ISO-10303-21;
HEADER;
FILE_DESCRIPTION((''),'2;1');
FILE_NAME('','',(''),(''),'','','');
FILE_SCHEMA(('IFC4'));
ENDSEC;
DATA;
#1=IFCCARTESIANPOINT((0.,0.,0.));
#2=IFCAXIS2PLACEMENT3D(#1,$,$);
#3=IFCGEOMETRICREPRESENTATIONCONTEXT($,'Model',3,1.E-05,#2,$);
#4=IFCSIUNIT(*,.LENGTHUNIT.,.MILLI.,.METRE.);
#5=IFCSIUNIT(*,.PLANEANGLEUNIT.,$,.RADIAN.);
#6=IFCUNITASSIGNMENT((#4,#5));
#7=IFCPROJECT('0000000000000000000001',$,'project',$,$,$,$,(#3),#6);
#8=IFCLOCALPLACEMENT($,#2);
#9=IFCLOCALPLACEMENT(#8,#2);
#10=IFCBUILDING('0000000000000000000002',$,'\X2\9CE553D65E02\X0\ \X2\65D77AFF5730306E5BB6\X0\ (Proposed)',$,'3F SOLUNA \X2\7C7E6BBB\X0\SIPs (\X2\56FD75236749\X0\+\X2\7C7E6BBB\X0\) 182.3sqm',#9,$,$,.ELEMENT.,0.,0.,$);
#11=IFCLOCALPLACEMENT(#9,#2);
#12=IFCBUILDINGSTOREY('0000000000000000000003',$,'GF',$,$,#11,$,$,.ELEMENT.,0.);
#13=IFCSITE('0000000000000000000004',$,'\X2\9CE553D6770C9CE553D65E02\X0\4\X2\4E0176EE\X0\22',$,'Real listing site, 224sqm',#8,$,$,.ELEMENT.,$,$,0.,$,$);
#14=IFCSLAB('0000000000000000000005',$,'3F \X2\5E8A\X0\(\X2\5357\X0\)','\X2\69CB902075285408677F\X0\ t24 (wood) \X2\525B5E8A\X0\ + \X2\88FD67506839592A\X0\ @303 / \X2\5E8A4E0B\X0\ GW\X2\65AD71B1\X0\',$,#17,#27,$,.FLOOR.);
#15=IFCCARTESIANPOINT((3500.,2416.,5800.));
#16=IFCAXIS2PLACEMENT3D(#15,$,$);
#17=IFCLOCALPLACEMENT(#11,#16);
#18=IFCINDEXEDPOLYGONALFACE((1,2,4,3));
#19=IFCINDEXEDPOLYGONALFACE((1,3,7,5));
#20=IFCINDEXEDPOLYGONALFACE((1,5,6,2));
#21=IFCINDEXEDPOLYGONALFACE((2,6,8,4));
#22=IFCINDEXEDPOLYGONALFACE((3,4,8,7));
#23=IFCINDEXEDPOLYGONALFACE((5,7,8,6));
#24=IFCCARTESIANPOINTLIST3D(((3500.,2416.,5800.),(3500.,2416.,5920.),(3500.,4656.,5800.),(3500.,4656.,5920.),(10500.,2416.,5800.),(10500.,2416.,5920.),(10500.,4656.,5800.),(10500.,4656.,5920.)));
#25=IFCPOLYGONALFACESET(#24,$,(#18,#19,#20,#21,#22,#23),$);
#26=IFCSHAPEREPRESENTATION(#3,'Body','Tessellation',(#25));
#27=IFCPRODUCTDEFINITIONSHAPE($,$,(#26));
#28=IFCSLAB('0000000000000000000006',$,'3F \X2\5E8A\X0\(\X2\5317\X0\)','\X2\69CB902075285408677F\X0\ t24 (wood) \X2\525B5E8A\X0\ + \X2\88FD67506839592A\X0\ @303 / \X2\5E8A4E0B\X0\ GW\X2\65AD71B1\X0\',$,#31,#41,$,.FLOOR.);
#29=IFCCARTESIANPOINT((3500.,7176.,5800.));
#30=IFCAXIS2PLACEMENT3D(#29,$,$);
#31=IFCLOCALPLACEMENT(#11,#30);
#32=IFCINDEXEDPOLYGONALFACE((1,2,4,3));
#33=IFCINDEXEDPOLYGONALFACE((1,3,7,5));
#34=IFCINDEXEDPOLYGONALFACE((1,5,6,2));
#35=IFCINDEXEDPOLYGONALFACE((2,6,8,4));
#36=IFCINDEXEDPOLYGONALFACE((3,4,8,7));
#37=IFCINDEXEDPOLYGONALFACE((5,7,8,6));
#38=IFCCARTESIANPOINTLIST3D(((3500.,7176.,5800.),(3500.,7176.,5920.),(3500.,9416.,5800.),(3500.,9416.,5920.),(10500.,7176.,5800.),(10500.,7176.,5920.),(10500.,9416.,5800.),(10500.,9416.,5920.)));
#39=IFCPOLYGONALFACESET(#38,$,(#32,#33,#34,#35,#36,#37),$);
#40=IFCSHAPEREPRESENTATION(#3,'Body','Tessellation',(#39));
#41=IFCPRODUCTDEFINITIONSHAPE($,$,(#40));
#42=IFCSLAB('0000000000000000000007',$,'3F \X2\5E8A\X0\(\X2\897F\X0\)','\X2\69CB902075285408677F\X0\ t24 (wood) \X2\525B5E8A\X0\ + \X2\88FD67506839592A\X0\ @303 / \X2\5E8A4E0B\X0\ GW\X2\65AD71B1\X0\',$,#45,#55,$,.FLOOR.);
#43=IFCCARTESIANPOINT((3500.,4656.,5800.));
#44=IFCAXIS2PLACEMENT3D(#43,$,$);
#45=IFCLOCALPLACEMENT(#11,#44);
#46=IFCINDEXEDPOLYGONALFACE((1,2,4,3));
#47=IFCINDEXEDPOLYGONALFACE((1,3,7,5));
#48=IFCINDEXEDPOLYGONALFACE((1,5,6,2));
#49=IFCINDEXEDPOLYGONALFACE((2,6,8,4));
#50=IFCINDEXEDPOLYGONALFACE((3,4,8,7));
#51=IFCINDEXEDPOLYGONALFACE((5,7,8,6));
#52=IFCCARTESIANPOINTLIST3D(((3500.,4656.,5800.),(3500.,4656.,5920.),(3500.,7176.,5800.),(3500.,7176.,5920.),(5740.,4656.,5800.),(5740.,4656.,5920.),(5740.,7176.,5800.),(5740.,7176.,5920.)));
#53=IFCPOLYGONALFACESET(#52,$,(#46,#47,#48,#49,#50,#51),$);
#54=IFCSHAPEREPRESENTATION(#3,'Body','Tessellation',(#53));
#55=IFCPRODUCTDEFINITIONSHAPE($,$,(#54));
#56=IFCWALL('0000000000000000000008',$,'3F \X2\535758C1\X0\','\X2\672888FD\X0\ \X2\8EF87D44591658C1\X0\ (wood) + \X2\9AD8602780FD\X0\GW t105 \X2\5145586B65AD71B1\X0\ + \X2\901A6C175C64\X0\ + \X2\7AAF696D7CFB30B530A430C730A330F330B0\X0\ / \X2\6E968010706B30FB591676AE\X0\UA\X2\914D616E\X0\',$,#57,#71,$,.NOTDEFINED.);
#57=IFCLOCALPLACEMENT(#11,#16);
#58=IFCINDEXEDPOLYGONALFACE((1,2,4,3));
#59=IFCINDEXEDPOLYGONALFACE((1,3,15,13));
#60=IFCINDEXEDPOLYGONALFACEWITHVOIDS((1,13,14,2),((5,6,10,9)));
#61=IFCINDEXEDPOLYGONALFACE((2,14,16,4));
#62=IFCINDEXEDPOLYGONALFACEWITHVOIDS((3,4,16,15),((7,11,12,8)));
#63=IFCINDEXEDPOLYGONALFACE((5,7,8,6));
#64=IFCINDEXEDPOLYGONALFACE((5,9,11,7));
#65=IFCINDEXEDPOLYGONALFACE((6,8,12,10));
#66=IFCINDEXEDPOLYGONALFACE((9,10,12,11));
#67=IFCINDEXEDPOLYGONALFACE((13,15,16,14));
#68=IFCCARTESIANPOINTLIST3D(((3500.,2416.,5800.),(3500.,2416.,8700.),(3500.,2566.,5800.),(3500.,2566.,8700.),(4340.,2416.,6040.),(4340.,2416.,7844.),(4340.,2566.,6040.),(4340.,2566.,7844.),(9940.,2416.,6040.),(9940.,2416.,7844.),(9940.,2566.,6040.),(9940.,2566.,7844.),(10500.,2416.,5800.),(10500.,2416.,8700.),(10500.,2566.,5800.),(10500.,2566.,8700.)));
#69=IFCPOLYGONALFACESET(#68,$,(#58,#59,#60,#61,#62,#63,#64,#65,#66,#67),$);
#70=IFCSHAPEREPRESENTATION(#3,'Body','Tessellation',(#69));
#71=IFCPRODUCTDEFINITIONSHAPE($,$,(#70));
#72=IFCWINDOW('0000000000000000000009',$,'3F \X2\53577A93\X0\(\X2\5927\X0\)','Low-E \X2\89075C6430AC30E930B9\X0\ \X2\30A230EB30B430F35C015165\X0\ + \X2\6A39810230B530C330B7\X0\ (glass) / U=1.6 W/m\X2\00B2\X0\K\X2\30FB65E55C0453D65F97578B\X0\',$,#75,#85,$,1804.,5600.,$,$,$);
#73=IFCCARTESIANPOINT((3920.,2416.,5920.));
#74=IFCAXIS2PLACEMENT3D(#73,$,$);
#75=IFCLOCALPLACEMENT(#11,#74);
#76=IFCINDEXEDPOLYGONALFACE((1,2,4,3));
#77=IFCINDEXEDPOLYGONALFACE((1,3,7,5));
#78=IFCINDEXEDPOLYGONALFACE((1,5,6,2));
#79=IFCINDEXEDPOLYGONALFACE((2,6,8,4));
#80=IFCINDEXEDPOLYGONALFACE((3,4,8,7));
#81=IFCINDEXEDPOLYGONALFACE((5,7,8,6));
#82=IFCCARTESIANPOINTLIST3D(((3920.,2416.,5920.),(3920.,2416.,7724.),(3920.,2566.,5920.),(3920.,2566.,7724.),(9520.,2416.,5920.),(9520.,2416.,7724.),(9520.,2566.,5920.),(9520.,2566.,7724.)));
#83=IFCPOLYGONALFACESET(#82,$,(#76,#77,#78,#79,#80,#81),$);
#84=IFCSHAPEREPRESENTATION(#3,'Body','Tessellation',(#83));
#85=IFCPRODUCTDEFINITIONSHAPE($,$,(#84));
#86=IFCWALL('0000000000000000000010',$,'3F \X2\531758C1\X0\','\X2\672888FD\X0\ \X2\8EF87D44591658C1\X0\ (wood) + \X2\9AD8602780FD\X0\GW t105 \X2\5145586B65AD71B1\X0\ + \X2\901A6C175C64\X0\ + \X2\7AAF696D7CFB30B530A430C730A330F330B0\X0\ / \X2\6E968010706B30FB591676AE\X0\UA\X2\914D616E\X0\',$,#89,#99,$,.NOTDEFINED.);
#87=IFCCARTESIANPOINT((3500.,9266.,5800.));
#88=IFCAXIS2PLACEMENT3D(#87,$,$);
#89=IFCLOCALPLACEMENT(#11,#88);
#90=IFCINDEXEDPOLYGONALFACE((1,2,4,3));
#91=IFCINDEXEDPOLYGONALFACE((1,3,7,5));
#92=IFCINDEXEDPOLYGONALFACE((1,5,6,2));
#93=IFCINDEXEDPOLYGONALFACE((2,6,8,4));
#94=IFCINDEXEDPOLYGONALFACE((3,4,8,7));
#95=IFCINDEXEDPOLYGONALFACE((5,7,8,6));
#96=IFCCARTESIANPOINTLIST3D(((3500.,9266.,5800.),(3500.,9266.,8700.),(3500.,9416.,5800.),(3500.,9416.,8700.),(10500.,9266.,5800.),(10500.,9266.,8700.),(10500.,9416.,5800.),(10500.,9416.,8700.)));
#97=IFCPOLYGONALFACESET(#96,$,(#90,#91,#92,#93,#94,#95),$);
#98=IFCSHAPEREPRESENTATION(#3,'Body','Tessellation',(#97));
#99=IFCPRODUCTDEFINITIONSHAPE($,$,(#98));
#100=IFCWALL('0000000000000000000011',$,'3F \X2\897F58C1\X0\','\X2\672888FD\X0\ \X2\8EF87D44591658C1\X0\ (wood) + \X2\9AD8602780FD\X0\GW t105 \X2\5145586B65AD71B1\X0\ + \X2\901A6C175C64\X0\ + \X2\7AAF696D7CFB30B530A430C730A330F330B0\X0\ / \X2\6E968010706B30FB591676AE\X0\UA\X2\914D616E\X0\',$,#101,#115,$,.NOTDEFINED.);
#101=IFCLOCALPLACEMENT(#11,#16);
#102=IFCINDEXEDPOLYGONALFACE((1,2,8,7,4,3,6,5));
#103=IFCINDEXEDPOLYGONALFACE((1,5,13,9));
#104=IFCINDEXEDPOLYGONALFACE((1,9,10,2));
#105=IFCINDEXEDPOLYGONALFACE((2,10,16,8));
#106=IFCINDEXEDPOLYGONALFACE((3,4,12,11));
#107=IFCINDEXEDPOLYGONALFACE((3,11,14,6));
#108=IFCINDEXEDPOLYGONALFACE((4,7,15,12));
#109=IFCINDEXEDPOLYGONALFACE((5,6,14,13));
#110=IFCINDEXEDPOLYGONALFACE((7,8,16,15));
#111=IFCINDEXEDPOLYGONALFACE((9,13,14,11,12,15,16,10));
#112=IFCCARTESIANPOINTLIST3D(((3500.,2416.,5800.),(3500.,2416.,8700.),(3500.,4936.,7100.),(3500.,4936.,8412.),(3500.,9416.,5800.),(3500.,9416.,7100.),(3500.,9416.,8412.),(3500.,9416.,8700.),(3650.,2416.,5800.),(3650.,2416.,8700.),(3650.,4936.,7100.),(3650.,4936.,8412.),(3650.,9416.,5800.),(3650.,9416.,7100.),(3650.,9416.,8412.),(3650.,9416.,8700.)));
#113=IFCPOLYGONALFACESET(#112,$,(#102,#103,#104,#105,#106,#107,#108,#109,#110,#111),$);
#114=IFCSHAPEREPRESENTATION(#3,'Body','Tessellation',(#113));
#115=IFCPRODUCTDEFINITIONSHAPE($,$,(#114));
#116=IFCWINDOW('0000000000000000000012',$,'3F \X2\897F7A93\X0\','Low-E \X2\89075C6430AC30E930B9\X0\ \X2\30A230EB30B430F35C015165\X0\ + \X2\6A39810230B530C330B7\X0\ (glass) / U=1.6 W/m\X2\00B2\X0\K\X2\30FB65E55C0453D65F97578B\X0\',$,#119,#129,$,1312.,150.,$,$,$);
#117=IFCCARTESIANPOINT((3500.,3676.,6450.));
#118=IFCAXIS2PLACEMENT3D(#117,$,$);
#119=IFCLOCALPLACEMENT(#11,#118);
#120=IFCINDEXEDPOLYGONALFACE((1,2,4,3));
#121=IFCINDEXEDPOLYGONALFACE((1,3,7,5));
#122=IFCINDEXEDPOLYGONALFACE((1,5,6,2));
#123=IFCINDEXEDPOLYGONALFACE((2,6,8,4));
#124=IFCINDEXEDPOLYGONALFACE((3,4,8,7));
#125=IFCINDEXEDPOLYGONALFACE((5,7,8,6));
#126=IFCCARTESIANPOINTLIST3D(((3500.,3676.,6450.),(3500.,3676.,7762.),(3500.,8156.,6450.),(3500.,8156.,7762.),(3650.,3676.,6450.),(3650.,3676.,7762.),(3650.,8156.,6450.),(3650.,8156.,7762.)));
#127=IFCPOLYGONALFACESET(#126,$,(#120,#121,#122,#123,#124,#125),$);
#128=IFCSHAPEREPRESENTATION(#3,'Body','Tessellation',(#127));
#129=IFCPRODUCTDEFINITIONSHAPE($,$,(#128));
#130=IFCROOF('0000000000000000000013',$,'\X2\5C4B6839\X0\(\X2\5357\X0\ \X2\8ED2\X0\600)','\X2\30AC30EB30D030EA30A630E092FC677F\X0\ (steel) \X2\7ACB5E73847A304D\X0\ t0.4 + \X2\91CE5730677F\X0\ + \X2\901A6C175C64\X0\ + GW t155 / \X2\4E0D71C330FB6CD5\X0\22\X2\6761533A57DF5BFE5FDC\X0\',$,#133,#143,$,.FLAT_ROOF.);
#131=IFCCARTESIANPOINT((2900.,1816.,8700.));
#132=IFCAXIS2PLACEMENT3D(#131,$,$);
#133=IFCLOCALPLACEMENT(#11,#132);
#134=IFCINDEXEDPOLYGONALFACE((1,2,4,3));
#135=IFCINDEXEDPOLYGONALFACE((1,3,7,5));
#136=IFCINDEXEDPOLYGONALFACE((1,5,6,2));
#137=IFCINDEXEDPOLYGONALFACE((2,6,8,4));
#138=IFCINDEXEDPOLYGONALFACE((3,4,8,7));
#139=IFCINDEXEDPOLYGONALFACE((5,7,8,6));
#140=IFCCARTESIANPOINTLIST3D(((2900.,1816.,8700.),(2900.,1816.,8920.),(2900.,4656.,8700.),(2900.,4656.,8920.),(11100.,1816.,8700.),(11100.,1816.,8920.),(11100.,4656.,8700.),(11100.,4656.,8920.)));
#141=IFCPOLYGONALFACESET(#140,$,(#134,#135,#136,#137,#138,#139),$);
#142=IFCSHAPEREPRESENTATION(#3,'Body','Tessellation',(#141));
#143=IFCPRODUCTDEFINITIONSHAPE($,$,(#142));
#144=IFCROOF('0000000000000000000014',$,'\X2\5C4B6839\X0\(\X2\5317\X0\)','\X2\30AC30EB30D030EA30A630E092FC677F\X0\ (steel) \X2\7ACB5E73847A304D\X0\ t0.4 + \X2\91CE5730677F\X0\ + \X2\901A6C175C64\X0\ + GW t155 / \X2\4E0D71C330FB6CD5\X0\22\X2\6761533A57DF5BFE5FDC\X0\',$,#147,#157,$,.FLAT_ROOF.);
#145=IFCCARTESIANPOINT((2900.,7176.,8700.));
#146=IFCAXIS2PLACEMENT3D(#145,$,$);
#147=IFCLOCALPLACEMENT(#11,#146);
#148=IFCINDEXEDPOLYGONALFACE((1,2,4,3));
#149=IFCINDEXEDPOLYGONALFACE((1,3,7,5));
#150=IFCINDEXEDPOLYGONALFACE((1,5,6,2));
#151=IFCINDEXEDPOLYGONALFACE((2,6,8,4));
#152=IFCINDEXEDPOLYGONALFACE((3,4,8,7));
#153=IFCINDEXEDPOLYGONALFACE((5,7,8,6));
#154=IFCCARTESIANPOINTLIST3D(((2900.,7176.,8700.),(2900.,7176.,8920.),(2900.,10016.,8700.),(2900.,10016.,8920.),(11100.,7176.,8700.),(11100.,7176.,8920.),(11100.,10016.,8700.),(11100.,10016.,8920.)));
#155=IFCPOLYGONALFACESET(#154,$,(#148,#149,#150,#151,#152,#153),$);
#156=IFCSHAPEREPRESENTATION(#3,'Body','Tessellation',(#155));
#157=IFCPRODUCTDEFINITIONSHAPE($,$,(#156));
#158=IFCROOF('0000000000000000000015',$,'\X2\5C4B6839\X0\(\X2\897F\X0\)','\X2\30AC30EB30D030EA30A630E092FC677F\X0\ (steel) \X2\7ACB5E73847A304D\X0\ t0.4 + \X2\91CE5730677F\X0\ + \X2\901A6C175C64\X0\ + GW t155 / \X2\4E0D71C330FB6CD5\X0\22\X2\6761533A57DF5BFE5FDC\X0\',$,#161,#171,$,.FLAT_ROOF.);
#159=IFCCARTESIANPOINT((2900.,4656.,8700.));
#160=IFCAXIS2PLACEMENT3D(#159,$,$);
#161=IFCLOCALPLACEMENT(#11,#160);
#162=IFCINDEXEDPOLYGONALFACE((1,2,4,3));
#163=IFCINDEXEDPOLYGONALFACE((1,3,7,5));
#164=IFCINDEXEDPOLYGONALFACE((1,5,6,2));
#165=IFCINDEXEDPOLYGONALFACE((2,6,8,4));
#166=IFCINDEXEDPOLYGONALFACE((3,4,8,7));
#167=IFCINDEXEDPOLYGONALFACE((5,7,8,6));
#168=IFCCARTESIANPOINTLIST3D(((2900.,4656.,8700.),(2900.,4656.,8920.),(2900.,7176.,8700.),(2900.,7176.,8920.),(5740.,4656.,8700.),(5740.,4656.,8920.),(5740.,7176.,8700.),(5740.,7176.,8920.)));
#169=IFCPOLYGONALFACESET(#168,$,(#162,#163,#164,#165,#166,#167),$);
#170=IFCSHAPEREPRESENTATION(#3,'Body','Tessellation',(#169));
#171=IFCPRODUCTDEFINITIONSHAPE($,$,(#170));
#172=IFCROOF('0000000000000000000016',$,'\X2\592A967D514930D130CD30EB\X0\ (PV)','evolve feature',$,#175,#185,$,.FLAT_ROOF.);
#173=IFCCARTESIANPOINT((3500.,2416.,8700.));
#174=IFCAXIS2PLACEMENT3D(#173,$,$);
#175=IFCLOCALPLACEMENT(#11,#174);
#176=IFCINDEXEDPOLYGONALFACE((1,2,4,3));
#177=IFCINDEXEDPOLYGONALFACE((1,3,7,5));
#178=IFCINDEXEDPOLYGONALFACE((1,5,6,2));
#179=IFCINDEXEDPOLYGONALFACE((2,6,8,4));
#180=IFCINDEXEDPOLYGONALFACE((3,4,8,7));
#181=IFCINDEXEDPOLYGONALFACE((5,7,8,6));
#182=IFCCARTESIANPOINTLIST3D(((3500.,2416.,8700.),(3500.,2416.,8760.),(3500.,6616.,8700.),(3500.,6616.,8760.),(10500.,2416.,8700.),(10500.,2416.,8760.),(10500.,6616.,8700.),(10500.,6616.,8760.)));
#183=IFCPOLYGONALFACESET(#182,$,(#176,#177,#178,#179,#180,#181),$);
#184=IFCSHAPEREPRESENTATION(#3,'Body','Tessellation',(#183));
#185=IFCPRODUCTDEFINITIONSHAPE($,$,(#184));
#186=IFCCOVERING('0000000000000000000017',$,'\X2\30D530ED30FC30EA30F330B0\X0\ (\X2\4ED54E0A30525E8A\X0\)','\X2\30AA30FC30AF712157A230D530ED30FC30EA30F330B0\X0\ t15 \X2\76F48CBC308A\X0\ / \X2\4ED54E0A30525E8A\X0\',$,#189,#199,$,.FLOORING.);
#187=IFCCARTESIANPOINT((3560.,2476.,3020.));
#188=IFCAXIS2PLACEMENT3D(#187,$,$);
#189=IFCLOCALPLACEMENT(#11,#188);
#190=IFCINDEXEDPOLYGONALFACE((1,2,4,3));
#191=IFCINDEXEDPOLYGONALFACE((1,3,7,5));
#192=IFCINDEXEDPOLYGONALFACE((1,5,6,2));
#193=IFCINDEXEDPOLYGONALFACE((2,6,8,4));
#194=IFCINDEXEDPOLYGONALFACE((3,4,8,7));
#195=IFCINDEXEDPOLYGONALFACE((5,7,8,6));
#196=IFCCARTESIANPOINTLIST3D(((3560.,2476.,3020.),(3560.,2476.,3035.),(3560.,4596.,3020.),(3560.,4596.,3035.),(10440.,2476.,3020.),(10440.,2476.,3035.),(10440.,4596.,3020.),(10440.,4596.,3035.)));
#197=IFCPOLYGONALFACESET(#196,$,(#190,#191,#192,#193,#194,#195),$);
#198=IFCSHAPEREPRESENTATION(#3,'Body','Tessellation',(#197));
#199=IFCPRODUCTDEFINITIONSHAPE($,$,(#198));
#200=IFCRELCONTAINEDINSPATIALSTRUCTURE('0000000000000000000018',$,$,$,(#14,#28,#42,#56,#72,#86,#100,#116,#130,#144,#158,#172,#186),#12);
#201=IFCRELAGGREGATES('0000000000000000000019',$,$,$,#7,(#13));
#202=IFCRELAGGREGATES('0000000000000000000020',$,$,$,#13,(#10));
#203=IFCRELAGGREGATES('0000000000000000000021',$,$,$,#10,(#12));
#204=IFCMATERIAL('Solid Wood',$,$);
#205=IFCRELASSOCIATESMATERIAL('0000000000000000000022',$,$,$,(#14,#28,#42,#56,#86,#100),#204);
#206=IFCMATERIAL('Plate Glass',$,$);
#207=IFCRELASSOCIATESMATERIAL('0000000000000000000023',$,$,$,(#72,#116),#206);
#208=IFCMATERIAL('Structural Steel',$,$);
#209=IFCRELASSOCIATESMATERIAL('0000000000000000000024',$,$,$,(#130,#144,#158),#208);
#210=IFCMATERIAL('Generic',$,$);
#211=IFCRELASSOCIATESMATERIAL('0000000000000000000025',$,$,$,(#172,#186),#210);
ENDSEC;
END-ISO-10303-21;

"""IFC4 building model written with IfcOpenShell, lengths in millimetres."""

from ifc_helpers import new_model, si_unit, frame, frame_2d, origin, place, context, project, spatial, rectangle, extrude, material, element, fill, save


model = new_model("IFC4")

# Units and contexts
model_context = context("Model", 3, precision=1e-05, world=origin())
ifc_project = project(units=[si_unit("LENGTHUNIT", "METRE", prefix="MILLI"), si_unit("PLANEANGLEUNIT", "RADIAN")], contexts=[model_context])

# Site, building, storey
site_placement = place(None, origin())
site = spatial("IfcSite", under=ifc_project, at=site_placement, Name="鳥取県鳥取市4丁目22", ObjectType="Real listing site, 224sqm", CompositionType="ELEMENT", RefElevation=0.0)
building_placement = place(site_placement, origin())
building = spatial("IfcBuilding", under=site, at=building_placement, Name="鳥取市 旗竿地の家 (Proposed)", ObjectType="3F SOLUNA 籾殻SIPs (国産杉+籾殻) 182.3sqm", CompositionType="ELEMENT", ElevationOfRefHeight=0.0, ElevationOfTerrain=0.0)
storey_placement = place(building_placement, origin())
storey = spatial("IfcBuildingStorey", under=building, at=storey_placement, Name="GF", CompositionType="ELEMENT", Elevation=0.0)

# Slabs
ifc_material_1 = material(Name="Solid Wood")
slab_1_placement = place(storey_placement, frame((3500.0, 2416.0, 5800.0)))
element("IfcSlab", 1, at=slab_1_placement, inside=storey, material=ifc_material_1, Name="3F 床(南)", Description="構造用合板 t24 (wood) 剛床 + 製材根太 @303 / 床下 GW断熱", PredefinedType="FLOOR", context=model_context, shape_type="SweptSolid", body=[
    extrude(rectangle(XDim=7000.0, YDim=2240.0, at=frame_2d((3500.0, 1120.0))), frame((3500.0, 2416.0, 5800.0)), (0.0, 0.0, 1.0), 120.0),
])
slab_2_placement = place(storey_placement, frame((3500.0, 7176.0, 5800.0)))
element("IfcSlab", 2, at=slab_2_placement, inside=storey, material=ifc_material_1, Name="3F 床(北)", Description="構造用合板 t24 (wood) 剛床 + 製材根太 @303 / 床下 GW断熱", PredefinedType="FLOOR", context=model_context, shape_type="SweptSolid", body=[
    extrude(rectangle(XDim=7000.0, YDim=2240.0, at=frame_2d((3500.0, 1120.0))), frame((3500.0, 7176.0, 5800.0)), (0.0, 0.0, 1.0), 120.0),
])
slab_3_placement = place(storey_placement, frame((3500.0, 4656.0, 5800.0)))
element("IfcSlab", 3, at=slab_3_placement, inside=storey, material=ifc_material_1, Name="3F 床(西)", Description="構造用合板 t24 (wood) 剛床 + 製材根太 @303 / 床下 GW断熱", PredefinedType="FLOOR", context=model_context, shape_type="SweptSolid", body=[
    extrude(rectangle(XDim=2240.0, YDim=2520.0, at=frame_2d((1120.0, 1260.0))), frame((3500.0, 4656.0, 5800.0)), (0.0, 0.0, 1.0), 120.0),
])

# Wall, opening, window
wall_1_placement = place(storey_placement, frame((3500.0, 2416.0, 5800.0)))
wall_1 = element("IfcWall", 4, at=wall_1_placement, inside=storey, material=ifc_material_1, Name="3F 南壁", Description="木製 軸組外壁 (wood) + 高性能GW t105 充填断熱 + 通気層 + 窯業系サイディング / 準耐火・外皮UA配慮", PredefinedType="NOTDEFINED", context=model_context, shape_type="SweptSolid", body=[
    extrude(rectangle(XDim=7000.0, YDim=150.0, at=frame_2d((3500.0, 75.0))), frame((3500.0, 2416.0, 5800.0)), (0.0, 0.0, 1.0), 2900.0),
])
opening_1_placement = place(storey_placement, frame((3920.0, 2416.0, 5920.0)))
opening_1 = element("IfcOpeningElement", 5, at=opening_1_placement, cuts=wall_1, PredefinedType="NOTDEFINED", context=model_context, shape_type="SweptSolid", body=[
    extrude(rectangle(XDim=5600.0, YDim=150.0, at=frame_2d((2800.0, 75.0))), frame((3920.0, 2416.0, 5920.0)), (0.0, 0.0, 1.0), 1804.0),
])
ifc_material_2 = material(Name="Plate Glass")
window_1_placement = place(storey_placement, frame((3920.0, 2416.0, 5920.0)))
window_1 = element("IfcWindow", 6, at=window_1_placement, inside=storey, material=ifc_material_2, Name="3F 南窓(大)", Description="Low-E 複層ガラス アルゴン封入 + 樹脂サッシ (glass) / U=1.6 W/m²K・日射取得型", OverallHeight=1804.0, OverallWidth=5600.0, context=model_context, shape_type="SweptSolid", body=[
    extrude(rectangle(XDim=5600.0, YDim=150.0, at=frame_2d((2800.0, 75.0))), frame((3920.0, 2416.0, 5920.0)), (0.0, 0.0, 1.0), 1804.0),
])
fill(opening_1, window_1)

# Wall
wall_2_placement = place(storey_placement, frame((3500.0, 9266.0, 5800.0)))
element("IfcWall", 7, at=wall_2_placement, inside=storey, material=ifc_material_1, Name="3F 北壁", Description="木製 軸組外壁 (wood) + 高性能GW t105 充填断熱 + 通気層 + 窯業系サイディング / 準耐火・外皮UA配慮", PredefinedType="NOTDEFINED", context=model_context, shape_type="SweptSolid", body=[
    extrude(rectangle(XDim=7000.0, YDim=150.0, at=frame_2d((3500.0, 75.0))), frame((3500.0, 9266.0, 5800.0)), (0.0, 0.0, 1.0), 2900.0),
])

# Wall, opening, window
wall_3_placement = place(storey_placement, frame((3500.0, 2416.0, 5800.0)))
wall_3 = element("IfcWall", 8, at=wall_3_placement, inside=storey, material=ifc_material_1, Name="3F 西壁", Description="木製 軸組外壁 (wood) + 高性能GW t105 充填断熱 + 通気層 + 窯業系サイディング / 準耐火・外皮UA配慮", PredefinedType="NOTDEFINED", context=model_context, shape_type="SweptSolid", body=[
    extrude(rectangle(XDim=150.0, YDim=7000.0, at=frame_2d((75.0, 3500.0))), frame((3500.0, 2416.0, 5800.0)), (0.0, 0.0, 1.0), 2900.0),
])
opening_2_placement = place(storey_placement, frame((3500.0, 3676.0, 6450.0)))
opening_2 = element("IfcOpeningElement", 9, at=opening_2_placement, cuts=wall_3, PredefinedType="NOTDEFINED", context=model_context, shape_type="SweptSolid", body=[
    extrude(rectangle(XDim=150.0, YDim=4480.0, at=frame_2d((75.0, 2240.0))), frame((3500.0, 3676.0, 6450.0)), (0.0, 0.0, 1.0), 1312.0),
])
window_2_placement = place(storey_placement, frame((3500.0, 3676.0, 6450.0)))
window_2 = element("IfcWindow", 10, at=window_2_placement, inside=storey, material=ifc_material_2, Name="3F 西窓", Description="Low-E 複層ガラス アルゴン封入 + 樹脂サッシ (glass) / U=1.6 W/m²K・日射取得型", OverallHeight=1312.0, OverallWidth=150.0, context=model_context, shape_type="SweptSolid", body=[
    extrude(rectangle(XDim=150.0, YDim=4480.0, at=frame_2d((75.0, 2240.0))), frame((3500.0, 3676.0, 6450.0)), (0.0, 0.0, 1.0), 1312.0),
])
fill(opening_2, window_2)

# Roofs
ifc_material_3 = material(Name="Structural Steel")
roof_1_placement = place(storey_placement, frame((2900.0, 1816.0, 8700.0)))
element("IfcRoof", 11, at=roof_1_placement, inside=storey, material=ifc_material_3, Name="屋根(南 軒600)", Description="ガルバリウム鋼板 (steel) 立平葺き t0.4 + 野地板 + 通気層 + GW t155 / 不燃・法22条区域対応", PredefinedType="FLAT_ROOF", context=model_context, shape_type="SweptSolid", body=[
    extrude(rectangle(XDim=8200.0, YDim=2840.0, at=frame_2d((4100.0, 1420.0))), frame((2900.0, 1816.0, 8700.0)), (0.0, 0.0, 1.0), 220.0),
])
roof_2_placement = place(storey_placement, frame((2900.0, 7176.0, 8700.0)))
element("IfcRoof", 12, at=roof_2_placement, inside=storey, material=ifc_material_3, Name="屋根(北)", Description="ガルバリウム鋼板 (steel) 立平葺き t0.4 + 野地板 + 通気層 + GW t155 / 不燃・法22条区域対応", PredefinedType="FLAT_ROOF", context=model_context, shape_type="SweptSolid", body=[
    extrude(rectangle(XDim=8200.0, YDim=2840.0, at=frame_2d((4100.0, 1420.0))), frame((2900.0, 7176.0, 8700.0)), (0.0, 0.0, 1.0), 220.0),
])
roof_3_placement = place(storey_placement, frame((2900.0, 4656.0, 8700.0)))
element("IfcRoof", 13, at=roof_3_placement, inside=storey, material=ifc_material_3, Name="屋根(西)", Description="ガルバリウム鋼板 (steel) 立平葺き t0.4 + 野地板 + 通気層 + GW t155 / 不燃・法22条区域対応", PredefinedType="FLAT_ROOF", context=model_context, shape_type="SweptSolid", body=[
    extrude(rectangle(XDim=2840.0, YDim=2520.0, at=frame_2d((1420.0, 1260.0))), frame((2900.0, 4656.0, 8700.0)), (0.0, 0.0, 1.0), 220.0),
])
ifc_material_4 = material(Name="Generic")
roof_4_placement = place(storey_placement, frame((3500.0, 2416.0, 8700.0)))
element("IfcRoof", 14, at=roof_4_placement, inside=storey, material=ifc_material_4, Name="太陽光パネル (PV)", Description="evolve feature", PredefinedType="FLAT_ROOF", context=model_context, shape_type="SweptSolid", body=[
    extrude(rectangle(XDim=7000.0, YDim=4200.0, at=frame_2d((3500.0, 2100.0))), frame((3500.0, 2416.0, 8700.0)), (0.0, 0.0, 1.0), 60.0),
])

# Covering
covering_1_placement = place(storey_placement, frame((3560.0, 2476.0, 3020.0)))
element("IfcCovering", 15, at=covering_1_placement, inside=storey, material=ifc_material_4, Name="フローリング (仕上げ床)", Description="オーク無垢フローリング t15 直貼り / 仕上げ床", PredefinedType="FLOORING", context=model_context, shape_type="SweptSolid", body=[
    extrude(rectangle(XDim=6880.0, YDim=2120.0, at=frame_2d((3440.0, 1060.0))), frame((3560.0, 2476.0, 3020.0)), (0.0, 0.0, 1.0), 15.0),
])

save(model, "model.ifc")
